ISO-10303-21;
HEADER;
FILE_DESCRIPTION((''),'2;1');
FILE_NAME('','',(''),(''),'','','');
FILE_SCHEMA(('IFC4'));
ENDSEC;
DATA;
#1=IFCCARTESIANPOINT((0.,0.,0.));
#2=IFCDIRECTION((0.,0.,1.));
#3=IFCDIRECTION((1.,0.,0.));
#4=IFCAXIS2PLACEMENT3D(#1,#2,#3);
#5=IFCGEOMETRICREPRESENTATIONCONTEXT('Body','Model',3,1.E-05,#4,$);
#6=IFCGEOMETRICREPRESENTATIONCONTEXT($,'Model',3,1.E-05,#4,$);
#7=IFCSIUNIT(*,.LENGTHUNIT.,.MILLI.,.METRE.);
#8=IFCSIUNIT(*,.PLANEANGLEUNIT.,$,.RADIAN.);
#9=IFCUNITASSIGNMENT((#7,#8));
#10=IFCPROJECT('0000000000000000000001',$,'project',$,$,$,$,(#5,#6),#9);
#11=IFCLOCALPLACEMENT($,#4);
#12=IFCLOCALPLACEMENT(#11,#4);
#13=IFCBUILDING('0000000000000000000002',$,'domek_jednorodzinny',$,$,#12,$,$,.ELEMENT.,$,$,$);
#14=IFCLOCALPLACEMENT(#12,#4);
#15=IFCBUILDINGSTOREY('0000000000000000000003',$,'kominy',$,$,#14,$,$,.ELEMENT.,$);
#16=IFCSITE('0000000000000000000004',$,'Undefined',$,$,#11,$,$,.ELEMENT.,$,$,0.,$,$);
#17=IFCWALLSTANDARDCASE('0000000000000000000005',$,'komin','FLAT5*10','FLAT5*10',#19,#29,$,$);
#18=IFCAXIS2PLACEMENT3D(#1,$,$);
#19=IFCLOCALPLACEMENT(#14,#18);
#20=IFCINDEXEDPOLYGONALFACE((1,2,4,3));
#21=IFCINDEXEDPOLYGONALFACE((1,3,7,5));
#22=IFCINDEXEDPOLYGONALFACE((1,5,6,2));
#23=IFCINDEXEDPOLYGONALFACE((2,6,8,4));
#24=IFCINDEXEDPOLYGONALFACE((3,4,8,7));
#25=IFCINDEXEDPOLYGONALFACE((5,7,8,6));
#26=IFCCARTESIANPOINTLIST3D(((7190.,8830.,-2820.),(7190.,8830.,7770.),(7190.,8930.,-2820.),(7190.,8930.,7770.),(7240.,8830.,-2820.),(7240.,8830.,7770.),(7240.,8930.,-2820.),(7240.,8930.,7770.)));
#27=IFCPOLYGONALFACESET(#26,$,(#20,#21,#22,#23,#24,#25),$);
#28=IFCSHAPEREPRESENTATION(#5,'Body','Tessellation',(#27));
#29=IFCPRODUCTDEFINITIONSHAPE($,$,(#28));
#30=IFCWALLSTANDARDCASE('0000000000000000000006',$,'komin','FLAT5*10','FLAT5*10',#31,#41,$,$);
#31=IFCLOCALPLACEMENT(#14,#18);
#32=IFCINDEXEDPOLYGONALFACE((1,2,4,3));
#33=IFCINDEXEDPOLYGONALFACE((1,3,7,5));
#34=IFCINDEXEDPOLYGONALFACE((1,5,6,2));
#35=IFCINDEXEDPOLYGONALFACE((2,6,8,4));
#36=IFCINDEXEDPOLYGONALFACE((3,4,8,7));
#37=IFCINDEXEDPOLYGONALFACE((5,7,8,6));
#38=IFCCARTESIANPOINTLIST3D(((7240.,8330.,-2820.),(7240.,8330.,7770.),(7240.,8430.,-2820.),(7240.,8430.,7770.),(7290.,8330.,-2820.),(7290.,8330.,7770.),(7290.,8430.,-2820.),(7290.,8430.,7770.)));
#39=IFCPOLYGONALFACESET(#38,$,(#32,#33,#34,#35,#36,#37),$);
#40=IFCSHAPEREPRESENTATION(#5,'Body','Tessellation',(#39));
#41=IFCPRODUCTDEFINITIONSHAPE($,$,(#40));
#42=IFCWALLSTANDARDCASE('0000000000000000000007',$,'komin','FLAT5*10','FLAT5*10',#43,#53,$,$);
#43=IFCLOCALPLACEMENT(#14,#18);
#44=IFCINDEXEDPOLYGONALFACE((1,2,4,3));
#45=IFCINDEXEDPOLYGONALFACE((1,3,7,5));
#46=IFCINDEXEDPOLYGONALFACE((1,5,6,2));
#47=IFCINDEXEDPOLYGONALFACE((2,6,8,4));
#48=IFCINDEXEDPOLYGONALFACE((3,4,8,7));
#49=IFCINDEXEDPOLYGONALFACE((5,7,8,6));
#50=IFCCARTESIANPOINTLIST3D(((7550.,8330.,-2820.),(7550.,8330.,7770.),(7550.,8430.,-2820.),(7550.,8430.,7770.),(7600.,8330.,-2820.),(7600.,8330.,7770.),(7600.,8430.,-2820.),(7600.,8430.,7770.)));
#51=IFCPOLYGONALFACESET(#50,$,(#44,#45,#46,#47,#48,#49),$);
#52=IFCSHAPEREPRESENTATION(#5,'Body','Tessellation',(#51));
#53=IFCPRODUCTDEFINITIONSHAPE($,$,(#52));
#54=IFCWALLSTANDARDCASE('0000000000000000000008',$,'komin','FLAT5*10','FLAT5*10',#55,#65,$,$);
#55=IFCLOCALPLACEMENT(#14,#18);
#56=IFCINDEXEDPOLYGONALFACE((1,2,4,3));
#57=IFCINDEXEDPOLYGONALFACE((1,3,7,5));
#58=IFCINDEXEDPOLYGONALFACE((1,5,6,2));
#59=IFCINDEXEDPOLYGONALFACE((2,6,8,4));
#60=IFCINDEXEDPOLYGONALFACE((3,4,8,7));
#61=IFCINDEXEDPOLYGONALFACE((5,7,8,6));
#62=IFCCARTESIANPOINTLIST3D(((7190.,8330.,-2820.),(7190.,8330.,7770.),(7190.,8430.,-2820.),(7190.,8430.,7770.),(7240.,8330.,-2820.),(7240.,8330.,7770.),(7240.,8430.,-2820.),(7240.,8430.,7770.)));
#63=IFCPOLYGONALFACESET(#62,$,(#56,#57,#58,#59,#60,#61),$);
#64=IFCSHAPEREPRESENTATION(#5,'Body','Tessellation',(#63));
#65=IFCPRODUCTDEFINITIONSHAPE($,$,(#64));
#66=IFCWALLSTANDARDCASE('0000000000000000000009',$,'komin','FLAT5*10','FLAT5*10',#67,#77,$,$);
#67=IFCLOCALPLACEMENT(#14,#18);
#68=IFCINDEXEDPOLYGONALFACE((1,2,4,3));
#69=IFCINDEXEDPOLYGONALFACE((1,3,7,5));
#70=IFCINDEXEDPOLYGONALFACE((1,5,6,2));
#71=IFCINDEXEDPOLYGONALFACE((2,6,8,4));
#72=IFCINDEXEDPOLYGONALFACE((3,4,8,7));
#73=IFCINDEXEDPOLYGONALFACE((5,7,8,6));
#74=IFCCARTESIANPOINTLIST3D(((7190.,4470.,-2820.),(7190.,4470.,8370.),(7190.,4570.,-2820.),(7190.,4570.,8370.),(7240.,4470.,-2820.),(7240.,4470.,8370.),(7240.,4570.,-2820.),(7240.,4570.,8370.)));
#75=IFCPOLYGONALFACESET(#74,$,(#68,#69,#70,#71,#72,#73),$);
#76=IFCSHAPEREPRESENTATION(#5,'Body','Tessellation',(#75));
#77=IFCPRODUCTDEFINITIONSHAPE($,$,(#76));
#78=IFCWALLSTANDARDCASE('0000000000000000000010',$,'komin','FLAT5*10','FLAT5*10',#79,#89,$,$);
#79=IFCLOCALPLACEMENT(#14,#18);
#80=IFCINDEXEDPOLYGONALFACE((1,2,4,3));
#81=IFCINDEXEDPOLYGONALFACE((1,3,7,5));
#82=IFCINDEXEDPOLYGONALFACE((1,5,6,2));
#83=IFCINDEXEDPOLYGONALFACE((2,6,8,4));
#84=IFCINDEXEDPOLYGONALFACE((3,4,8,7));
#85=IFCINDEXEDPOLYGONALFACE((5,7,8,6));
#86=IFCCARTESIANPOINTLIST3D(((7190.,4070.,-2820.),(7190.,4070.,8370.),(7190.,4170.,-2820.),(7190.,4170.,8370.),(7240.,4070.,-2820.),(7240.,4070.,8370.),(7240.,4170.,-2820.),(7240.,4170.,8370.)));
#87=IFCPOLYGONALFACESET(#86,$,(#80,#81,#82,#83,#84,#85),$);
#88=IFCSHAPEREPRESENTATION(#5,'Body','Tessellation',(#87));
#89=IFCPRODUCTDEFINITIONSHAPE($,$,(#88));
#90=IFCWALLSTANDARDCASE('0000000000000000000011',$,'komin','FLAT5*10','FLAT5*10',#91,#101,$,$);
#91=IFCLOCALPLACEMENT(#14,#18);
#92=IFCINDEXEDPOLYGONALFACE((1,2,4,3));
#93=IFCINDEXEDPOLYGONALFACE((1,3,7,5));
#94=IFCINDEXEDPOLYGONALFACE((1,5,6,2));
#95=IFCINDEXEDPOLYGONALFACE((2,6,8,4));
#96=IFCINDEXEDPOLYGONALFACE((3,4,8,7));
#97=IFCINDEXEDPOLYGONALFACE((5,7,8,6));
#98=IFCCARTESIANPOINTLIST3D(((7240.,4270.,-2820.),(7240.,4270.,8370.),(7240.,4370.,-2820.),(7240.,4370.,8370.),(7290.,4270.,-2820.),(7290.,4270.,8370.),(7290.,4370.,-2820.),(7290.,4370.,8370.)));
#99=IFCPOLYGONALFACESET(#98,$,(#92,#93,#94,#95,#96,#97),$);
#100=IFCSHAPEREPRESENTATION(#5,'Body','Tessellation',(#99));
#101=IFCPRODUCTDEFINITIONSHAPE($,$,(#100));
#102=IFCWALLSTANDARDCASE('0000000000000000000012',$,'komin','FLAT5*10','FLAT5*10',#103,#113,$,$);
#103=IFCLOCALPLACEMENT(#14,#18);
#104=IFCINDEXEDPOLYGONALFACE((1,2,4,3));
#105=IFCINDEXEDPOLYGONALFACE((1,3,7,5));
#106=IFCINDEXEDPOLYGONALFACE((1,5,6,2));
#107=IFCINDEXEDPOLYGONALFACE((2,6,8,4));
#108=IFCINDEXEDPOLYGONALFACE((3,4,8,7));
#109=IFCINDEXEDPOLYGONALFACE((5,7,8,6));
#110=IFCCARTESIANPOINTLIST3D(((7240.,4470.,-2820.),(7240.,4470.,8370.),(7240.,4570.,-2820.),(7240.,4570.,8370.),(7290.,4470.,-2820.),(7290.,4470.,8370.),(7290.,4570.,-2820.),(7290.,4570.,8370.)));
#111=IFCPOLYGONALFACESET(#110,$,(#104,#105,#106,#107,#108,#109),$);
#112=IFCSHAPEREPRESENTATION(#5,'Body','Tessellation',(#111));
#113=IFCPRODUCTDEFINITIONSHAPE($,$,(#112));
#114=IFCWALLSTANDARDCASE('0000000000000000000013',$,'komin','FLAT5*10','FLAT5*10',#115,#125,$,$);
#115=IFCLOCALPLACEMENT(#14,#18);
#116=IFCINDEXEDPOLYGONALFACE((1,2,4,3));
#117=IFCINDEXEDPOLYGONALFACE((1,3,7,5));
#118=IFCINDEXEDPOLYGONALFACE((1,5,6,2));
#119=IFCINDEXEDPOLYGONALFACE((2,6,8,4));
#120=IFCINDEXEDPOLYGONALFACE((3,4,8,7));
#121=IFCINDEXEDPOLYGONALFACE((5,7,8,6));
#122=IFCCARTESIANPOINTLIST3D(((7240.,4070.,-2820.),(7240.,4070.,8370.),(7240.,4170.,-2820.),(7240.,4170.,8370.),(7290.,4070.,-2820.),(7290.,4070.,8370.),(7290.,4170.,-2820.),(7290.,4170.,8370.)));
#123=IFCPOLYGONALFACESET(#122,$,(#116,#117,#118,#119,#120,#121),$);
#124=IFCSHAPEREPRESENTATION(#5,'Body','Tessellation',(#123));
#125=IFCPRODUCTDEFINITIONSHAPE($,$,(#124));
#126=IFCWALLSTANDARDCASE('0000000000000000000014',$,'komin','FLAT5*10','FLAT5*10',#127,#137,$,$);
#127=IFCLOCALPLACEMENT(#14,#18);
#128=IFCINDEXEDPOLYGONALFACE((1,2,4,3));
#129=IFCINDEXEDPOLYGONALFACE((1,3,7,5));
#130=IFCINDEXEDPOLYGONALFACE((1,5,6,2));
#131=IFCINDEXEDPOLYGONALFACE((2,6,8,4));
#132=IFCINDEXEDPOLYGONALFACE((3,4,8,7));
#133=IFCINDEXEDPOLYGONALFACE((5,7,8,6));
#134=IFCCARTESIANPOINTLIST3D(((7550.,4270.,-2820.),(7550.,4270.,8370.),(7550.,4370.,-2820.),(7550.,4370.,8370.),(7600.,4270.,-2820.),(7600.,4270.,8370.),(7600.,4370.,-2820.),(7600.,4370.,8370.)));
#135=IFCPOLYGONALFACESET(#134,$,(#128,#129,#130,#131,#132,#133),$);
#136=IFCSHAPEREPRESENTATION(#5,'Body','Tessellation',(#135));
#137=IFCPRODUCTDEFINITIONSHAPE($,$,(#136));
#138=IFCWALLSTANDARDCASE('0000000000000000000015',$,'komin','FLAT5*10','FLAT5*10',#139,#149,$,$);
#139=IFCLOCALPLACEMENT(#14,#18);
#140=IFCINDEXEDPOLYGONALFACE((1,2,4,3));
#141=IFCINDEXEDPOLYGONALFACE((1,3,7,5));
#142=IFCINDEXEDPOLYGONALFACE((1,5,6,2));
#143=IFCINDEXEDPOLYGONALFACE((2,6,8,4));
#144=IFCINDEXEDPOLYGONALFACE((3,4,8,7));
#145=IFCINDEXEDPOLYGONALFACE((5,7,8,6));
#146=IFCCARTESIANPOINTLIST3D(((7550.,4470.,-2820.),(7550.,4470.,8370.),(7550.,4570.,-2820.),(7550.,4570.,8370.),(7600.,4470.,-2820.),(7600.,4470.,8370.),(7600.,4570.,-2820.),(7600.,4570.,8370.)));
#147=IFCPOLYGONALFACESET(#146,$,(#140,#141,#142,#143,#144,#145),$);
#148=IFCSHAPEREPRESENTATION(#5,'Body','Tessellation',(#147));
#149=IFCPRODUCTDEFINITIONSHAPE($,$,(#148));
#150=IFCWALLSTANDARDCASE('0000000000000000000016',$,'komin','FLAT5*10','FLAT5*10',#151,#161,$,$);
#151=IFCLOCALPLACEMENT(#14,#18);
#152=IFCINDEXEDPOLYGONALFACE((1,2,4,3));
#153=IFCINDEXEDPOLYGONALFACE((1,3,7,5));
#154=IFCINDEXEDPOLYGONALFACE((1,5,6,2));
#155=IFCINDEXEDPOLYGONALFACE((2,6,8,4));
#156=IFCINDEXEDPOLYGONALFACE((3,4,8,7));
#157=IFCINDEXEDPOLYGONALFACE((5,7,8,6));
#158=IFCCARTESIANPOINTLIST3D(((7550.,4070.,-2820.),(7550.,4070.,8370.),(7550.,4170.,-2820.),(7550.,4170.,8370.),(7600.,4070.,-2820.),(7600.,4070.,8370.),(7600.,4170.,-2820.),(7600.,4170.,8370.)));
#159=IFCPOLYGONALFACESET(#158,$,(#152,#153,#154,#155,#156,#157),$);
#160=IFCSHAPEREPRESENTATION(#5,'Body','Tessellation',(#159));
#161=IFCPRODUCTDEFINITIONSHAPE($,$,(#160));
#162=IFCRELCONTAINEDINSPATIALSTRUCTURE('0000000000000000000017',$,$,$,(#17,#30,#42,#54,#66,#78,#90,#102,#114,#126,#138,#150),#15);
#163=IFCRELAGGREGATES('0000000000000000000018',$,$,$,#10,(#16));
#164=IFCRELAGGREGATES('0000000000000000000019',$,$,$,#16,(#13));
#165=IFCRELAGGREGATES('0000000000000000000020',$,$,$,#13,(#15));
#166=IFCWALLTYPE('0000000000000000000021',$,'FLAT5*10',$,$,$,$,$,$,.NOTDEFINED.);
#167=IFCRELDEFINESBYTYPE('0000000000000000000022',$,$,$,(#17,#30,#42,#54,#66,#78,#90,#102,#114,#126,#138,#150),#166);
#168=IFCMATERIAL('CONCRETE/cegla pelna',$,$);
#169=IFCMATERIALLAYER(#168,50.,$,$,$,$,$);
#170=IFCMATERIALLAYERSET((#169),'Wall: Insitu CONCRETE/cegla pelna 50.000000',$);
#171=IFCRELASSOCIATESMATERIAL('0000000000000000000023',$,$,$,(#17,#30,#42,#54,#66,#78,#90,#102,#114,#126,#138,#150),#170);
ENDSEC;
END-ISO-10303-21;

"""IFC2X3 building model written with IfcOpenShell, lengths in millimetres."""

from ifc_helpers import new_model, si_unit, frame, frame_2d, origin_with_axes, place, context, project, spatial, rectangle, extrude, material, layer, layer_set, layer_usage, type_object, element, save


model = new_model("IFC2X3")

# Units and contexts
model_context_1 = context("Model", 3, precision=1e-05, world=origin_with_axes(), identifier="Body")
model_context_2 = context("Model", 3, precision=1e-05, world=origin_with_axes())
ifc_project = project(units=[si_unit("LENGTHUNIT", "METRE", prefix="MILLI"), si_unit("PLANEANGLEUNIT", "RADIAN")], contexts=[model_context_1, model_context_2])

# Site, building, storey
site_placement = place(None, origin_with_axes())
site = spatial("IfcSite", under=ifc_project, at=site_placement, Name="Undefined", CompositionType="ELEMENT", RefElevation=0.0)
building_placement = place(site_placement, origin_with_axes())
building = spatial("IfcBuilding", under=site, at=building_placement, Name="domek_jednorodzinny", CompositionType="ELEMENT")
storey_placement = place(building_placement, origin_with_axes())
storey = spatial("IfcBuildingStorey", under=building, at=storey_placement, Name="kominy", CompositionType="ELEMENT")

# Walls
ifc_material = material(Name="CONCRETE/cegla pelna")
ifc_layer = layer(ifc_material, 50.0)
ifc_layer_set = layer_set([ifc_layer], Name="Wall: Insitu CONCRETE/cegla pelna 50.000000")
wall_type_1 = type_object("IfcWallType", Name="FLAT5*10", PredefinedType="NOTDEFINED")
ifc_layer_usage_1 = layer_usage(ifc_layer_set, "AXIS2", "POSITIVE", -25.0)
wall_1_placement = place(storey_placement, frame((7215.0, 8830.0, -2820.0), z_axis=(0.0, 0.0, 1.0), x_axis=(0.0, 1.0, 0.0)))
element("IfcWallStandardCase", 1, at=wall_1_placement, inside=storey, type_object=wall_type_1, material=ifc_layer_usage_1, Name="komin", Description="FLAT5*10", ObjectType="FLAT5*10", context=model_context_1, shape_type="SweptSolid", body=[
    extrude(rectangle(XDim=100.0, YDim=50.0, at=frame_2d((0.0, 50.0), x_axis=(0.0, -1.0))), frame((0.0, 0.0, 0.0), z_axis=(0.0, 0.0, 1.0), x_axis=(0.0, -1.0, 0.0)), (0.0, 0.0, 1.0), 10590.0),
])
ifc_layer_usage_2 = layer_usage(ifc_layer_set, "AXIS2", "POSITIVE", -25.0)
wall_2_placement = place(storey_placement, frame((7265.0, 8330.0, -2820.0), z_axis=(0.0, 0.0, 1.0), x_axis=(0.0, 1.0, 0.0)))
element("IfcWallStandardCase", 2, at=wall_2_placement, inside=storey, type_object=wall_type_1, material=ifc_layer_usage_2, Name="komin", Description="FLAT5*10", ObjectType="FLAT5*10", context=model_context_1, shape_type="SweptSolid", body=[
    extrude(rectangle(XDim=100.0, YDim=50.0, at=frame_2d((0.0, 50.0), x_axis=(0.0, -1.0))), frame((0.0, 0.0, 0.0), z_axis=(0.0, 0.0, 1.0), x_axis=(0.0, -1.0, 0.0)), (0.0, 0.0, 1.0), 10590.0),
])
ifc_layer_usage_3 = layer_usage(ifc_layer_set, "AXIS2", "POSITIVE", -25.0)
wall_3_placement = place(storey_placement, frame((7575.0, 8330.0, -2820.0), z_axis=(0.0, 0.0, 1.0), x_axis=(0.0, 1.0, 0.0)))
element("IfcWallStandardCase", 3, at=wall_3_placement, inside=storey, type_object=wall_type_1, material=ifc_layer_usage_3, Name="komin", Description="FLAT5*10", ObjectType="FLAT5*10", context=model_context_1, shape_type="SweptSolid", body=[
    extrude(rectangle(XDim=100.0, YDim=50.0, at=frame_2d((0.0, 50.0), x_axis=(0.0, -1.0))), frame((0.0, 0.0, 0.0), z_axis=(0.0, 0.0, 1.0), x_axis=(0.0, -1.0, 0.0)), (0.0, 0.0, 1.0), 10590.0),
])
ifc_layer_usage_4 = layer_usage(ifc_layer_set, "AXIS2", "POSITIVE", -25.0)
wall_4_placement = place(storey_placement, frame((7215.0, 8330.0, -2820.0), z_axis=(0.0, 0.0, 1.0), x_axis=(0.0, 1.0, 0.0)))
element("IfcWallStandardCase", 4, at=wall_4_placement, inside=storey, type_object=wall_type_1, material=ifc_layer_usage_4, Name="komin", Description="FLAT5*10", ObjectType="FLAT5*10", context=model_context_1, shape_type="SweptSolid", body=[
    extrude(rectangle(XDim=100.0, YDim=50.0, at=frame_2d((0.0, 50.0), x_axis=(0.0, -1.0))), frame((0.0, 0.0, 0.0), z_axis=(0.0, 0.0, 1.0), x_axis=(0.0, -1.0, 0.0)), (0.0, 0.0, 1.0), 10590.0),
])
ifc_layer_usage_5 = layer_usage(ifc_layer_set, "AXIS2", "POSITIVE", -25.0)
wall_5_placement = place(storey_placement, frame((7215.0, 4470.0, -2820.0), z_axis=(0.0, 0.0, 1.0), x_axis=(0.0, 1.0, 0.0)))
element("IfcWallStandardCase", 5, at=wall_5_placement, inside=storey, type_object=wall_type_1, material=ifc_layer_usage_5, Name="komin", Description="FLAT5*10", ObjectType="FLAT5*10", context=model_context_1, shape_type="SweptSolid", body=[
    extrude(rectangle(XDim=100.0, YDim=50.0, at=frame_2d((0.0, 50.0), x_axis=(0.0, -1.0))), frame((0.0, 0.0, 0.0), z_axis=(0.0, 0.0, 1.0), x_axis=(0.0, -1.0, 0.0)), (0.0, 0.0, 1.0), 11190.0),
])
ifc_layer_usage_6 = layer_usage(ifc_layer_set, "AXIS2", "POSITIVE", -25.0)
wall_6_placement = place(storey_placement, frame((7215.0, 4070.0, -2820.0), z_axis=(0.0, 0.0, 1.0), x_axis=(0.0, 1.0, 0.0)))
element("IfcWallStandardCase", 6, at=wall_6_placement, inside=storey, type_object=wall_type_1, material=ifc_layer_usage_6, Name="komin", Description="FLAT5*10", ObjectType="FLAT5*10", context=model_context_1, shape_type="SweptSolid", body=[
    extrude(rectangle(XDim=100.0, YDim=50.0, at=frame_2d((0.0, 50.0), x_axis=(0.0, -1.0))), frame((0.0, 0.0, 0.0), z_axis=(0.0, 0.0, 1.0), x_axis=(0.0, -1.0, 0.0)), (0.0, 0.0, 1.0), 11190.0),
])
ifc_layer_usage_7 = layer_usage(ifc_layer_set, "AXIS2", "POSITIVE", -25.0)
wall_7_placement = place(storey_placement, frame((7265.0, 4270.0, -2820.0), z_axis=(0.0, 0.0, 1.0), x_axis=(0.0, 1.0, 0.0)))
element("IfcWallStandardCase", 7, at=wall_7_placement, inside=storey, type_object=wall_type_1, material=ifc_layer_usage_7, Name="komin", Description="FLAT5*10", ObjectType="FLAT5*10", context=model_context_1, shape_type="SweptSolid", body=[
    extrude(rectangle(XDim=100.0, YDim=50.0, at=frame_2d((0.0, 50.0), x_axis=(0.0, -1.0))), frame((0.0, 0.0, 0.0), z_axis=(0.0, 0.0, 1.0), x_axis=(0.0, -1.0, 0.0)), (0.0, 0.0, 1.0), 11190.0),
])
ifc_layer_usage_8 = layer_usage(ifc_layer_set, "AXIS2", "POSITIVE", -25.0)
wall_8_placement = place(storey_placement, frame((7265.0, 4470.0, -2820.0), z_axis=(0.0, 0.0, 1.0), x_axis=(0.0, 1.0, 0.0)))
element("IfcWallStandardCase", 8, at=wall_8_placement, inside=storey, type_object=wall_type_1, material=ifc_layer_usage_8, Name="komin", Description="FLAT5*10", ObjectType="FLAT5*10", context=model_context_1, shape_type="SweptSolid", body=[
    extrude(rectangle(XDim=100.0, YDim=50.0, at=frame_2d((0.0, 50.0), x_axis=(0.0, -1.0))), frame((0.0, 0.0, 0.0), z_axis=(0.0, 0.0, 1.0), x_axis=(0.0, -1.0, 0.0)), (0.0, 0.0, 1.0), 11190.0),
])
ifc_layer_usage_9 = layer_usage(ifc_layer_set, "AXIS2", "POSITIVE", -25.0)
wall_9_placement = place(storey_placement, frame((7265.0, 4070.0, -2820.0), z_axis=(0.0, 0.0, 1.0), x_axis=(0.0, 1.0, 0.0)))
element("IfcWallStandardCase", 9, at=wall_9_placement, inside=storey, type_object=wall_type_1, material=ifc_layer_usage_9, Name="komin", Description="FLAT5*10", ObjectType="FLAT5*10", context=model_context_1, shape_type="SweptSolid", body=[
    extrude(rectangle(XDim=100.0, YDim=50.0, at=frame_2d((0.0, 50.0), x_axis=(0.0, -1.0))), frame((0.0, 0.0, 0.0), z_axis=(0.0, 0.0, 1.0), x_axis=(0.0, -1.0, 0.0)), (0.0, 0.0, 1.0), 11190.0),
])
ifc_layer_usage_10 = layer_usage(ifc_layer_set, "AXIS2", "POSITIVE", -25.0)
wall_10_placement = place(storey_placement, frame((7575.0, 4270.0, -2820.0), z_axis=(0.0, 0.0, 1.0), x_axis=(0.0, 1.0, 0.0)))
element("IfcWallStandardCase", 10, at=wall_10_placement, inside=storey, type_object=wall_type_1, material=ifc_layer_usage_10, Name="komin", Description="FLAT5*10", ObjectType="FLAT5*10", context=model_context_1, shape_type="SweptSolid", body=[
    extrude(rectangle(XDim=100.0, YDim=50.0, at=frame_2d((0.0, 50.0), x_axis=(0.0, -1.0))), frame((0.0, 0.0, 0.0), z_axis=(0.0, 0.0, 1.0), x_axis=(0.0, -1.0, 0.0)), (0.0, 0.0, 1.0), 11190.0),
])
ifc_layer_usage_11 = layer_usage(ifc_layer_set, "AXIS2", "POSITIVE", -25.0)
wall_11_placement = place(storey_placement, frame((7575.0, 4470.0, -2820.0), z_axis=(0.0, 0.0, 1.0), x_axis=(0.0, 1.0, 0.0)))
element("IfcWallStandardCase", 11, at=wall_11_placement, inside=storey, type_object=wall_type_1, material=ifc_layer_usage_11, Name="komin", Description="FLAT5*10", ObjectType="FLAT5*10", context=model_context_1, shape_type="SweptSolid", body=[
    extrude(rectangle(XDim=100.0, YDim=50.0, at=frame_2d((0.0, 50.0), x_axis=(0.0, -1.0))), frame((0.0, 0.0, 0.0), z_axis=(0.0, 0.0, 1.0), x_axis=(0.0, -1.0, 0.0)), (0.0, 0.0, 1.0), 11190.0),
])
ifc_layer_usage_12 = layer_usage(ifc_layer_set, "AXIS2", "POSITIVE", -25.0)
wall_12_placement = place(storey_placement, frame((7575.0, 4070.0, -2820.0), z_axis=(0.0, 0.0, 1.0), x_axis=(0.0, 1.0, 0.0)))
element("IfcWallStandardCase", 12, at=wall_12_placement, inside=storey, type_object=wall_type_1, material=ifc_layer_usage_12, Name="komin", Description="FLAT5*10", ObjectType="FLAT5*10", context=model_context_1, shape_type="SweptSolid", body=[
    extrude(rectangle(XDim=100.0, YDim=50.0, at=frame_2d((0.0, 50.0), x_axis=(0.0, -1.0))), frame((0.0, 0.0, 0.0), z_axis=(0.0, 0.0, 1.0), x_axis=(0.0, -1.0, 0.0)), (0.0, 0.0, 1.0), 11190.0),
])

save(model, "model.ifc")
